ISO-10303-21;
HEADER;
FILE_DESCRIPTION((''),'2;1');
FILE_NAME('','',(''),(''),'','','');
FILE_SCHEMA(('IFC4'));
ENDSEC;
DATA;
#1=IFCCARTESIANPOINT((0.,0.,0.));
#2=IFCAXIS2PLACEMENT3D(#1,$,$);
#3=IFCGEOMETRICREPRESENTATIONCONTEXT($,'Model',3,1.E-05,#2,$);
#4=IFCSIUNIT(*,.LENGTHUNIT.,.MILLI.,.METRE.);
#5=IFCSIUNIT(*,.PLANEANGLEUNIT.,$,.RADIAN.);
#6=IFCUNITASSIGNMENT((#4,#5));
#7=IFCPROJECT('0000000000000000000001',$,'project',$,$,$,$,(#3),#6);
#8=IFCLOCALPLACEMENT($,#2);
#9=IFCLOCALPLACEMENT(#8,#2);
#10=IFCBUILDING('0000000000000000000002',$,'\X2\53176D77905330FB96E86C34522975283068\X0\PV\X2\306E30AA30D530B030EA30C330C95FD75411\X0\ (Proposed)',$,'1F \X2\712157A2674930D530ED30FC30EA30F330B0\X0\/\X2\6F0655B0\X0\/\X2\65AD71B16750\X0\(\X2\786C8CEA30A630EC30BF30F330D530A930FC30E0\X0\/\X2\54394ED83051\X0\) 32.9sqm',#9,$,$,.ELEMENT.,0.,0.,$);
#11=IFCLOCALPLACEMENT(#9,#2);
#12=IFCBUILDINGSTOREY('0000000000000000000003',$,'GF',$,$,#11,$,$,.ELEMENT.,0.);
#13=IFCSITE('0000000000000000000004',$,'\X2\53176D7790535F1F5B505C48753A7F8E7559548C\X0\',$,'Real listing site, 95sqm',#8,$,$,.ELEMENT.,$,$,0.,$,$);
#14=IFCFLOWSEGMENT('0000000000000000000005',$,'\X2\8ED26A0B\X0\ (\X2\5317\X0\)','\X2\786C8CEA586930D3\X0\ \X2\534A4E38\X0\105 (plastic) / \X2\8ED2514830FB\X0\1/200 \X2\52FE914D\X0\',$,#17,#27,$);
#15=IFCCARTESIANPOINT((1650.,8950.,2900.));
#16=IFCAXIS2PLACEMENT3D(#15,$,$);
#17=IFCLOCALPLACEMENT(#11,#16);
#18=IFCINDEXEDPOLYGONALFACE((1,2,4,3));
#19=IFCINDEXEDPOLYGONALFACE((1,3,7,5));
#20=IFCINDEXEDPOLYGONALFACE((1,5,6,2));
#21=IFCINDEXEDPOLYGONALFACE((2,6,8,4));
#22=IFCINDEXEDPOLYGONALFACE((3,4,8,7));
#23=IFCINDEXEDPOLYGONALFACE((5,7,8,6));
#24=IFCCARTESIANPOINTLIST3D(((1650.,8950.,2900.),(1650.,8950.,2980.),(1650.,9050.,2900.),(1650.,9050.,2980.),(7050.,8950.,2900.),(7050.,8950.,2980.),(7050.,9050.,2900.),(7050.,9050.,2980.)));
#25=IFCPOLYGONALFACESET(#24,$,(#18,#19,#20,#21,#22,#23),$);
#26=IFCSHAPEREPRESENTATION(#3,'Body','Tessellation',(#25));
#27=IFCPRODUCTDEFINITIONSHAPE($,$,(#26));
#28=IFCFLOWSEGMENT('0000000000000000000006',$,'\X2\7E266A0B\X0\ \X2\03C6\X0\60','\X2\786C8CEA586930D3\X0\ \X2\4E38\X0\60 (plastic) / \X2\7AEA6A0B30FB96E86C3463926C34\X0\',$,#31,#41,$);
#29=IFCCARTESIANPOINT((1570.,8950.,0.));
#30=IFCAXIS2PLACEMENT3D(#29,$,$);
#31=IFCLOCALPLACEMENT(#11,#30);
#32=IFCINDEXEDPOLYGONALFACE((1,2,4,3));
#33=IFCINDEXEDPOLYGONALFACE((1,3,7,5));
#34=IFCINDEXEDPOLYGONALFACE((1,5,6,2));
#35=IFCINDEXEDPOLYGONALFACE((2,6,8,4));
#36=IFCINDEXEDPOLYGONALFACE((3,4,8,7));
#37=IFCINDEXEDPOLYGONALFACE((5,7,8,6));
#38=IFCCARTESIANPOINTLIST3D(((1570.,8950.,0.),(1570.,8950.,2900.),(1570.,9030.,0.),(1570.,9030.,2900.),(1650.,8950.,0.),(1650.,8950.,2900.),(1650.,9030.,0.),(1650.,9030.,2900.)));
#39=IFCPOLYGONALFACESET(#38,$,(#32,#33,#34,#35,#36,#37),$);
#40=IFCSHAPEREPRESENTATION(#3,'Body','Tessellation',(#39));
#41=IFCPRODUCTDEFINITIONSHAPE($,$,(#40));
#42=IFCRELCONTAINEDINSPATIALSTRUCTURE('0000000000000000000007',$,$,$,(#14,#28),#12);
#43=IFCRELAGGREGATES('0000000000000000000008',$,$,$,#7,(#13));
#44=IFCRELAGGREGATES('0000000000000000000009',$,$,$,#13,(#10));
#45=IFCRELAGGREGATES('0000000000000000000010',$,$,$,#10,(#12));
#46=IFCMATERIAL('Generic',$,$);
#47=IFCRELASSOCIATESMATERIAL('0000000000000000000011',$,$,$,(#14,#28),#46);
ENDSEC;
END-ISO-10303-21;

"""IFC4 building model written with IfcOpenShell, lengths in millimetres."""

from ifc_helpers import new_model, si_unit, frame, frame_2d, origin, place, context, project, spatial, rectangle, extrude, material, element, save


model = new_model("IFC4")

# Units and contexts
model_context = context("Model", 3, precision=1e-05, world=origin())
ifc_project = project(units=[si_unit("LENGTHUNIT", "METRE", prefix="MILLI"), si_unit("PLANEANGLEUNIT", "RADIAN")], contexts=[model_context])

# Site, building, storey
site_placement = place(None, origin())
site = spatial("IfcSite", under=ifc_project, at=site_placement, Name="北海道弟子屈町美留和", ObjectType="Real listing site, 95sqm", CompositionType="ELEMENT", RefElevation=0.0)
building_placement = place(site_placement, origin())
building = spatial("IfcBuilding", under=site, at=building_placement, Name="北海道・雨水利用とPVのオフグリッド志向 (Proposed)", ObjectType="1F 無垢杉フローリング/漆喰/断熱材(硬質ウレタンフォーム/吹付け) 32.9sqm", CompositionType="ELEMENT", ElevationOfRefHeight=0.0, ElevationOfTerrain=0.0)
storey_placement = place(building_placement, origin())
storey = spatial("IfcBuildingStorey", under=building, at=storey_placement, Name="GF", CompositionType="ELEMENT", Elevation=0.0)

# Shared definitions
ifc_material_1 = material(Name="Generic")

# Flow segments
flow_segment_1_placement = place(storey_placement, frame((1650.0, 8950.0, 2900.0)))
element("IfcFlowSegment", 1, at=flow_segment_1_placement, inside=storey, material=ifc_material_1, Name="軒樋 (北)", Description="硬質塩ビ 半丸105 (plastic) / 軒先・1/200 勾配", context=model_context, shape_type="SweptSolid", body=[
    extrude(rectangle(XDim=5400.0, YDim=100.0, at=frame_2d((2700.0, 50.0))), frame((1650.0, 8950.0, 2900.0)), (0.0, 0.0, 1.0), 80.0),
])
flow_segment_2_placement = place(storey_placement, frame((1570.0, 8950.0, 0.0)))
element("IfcFlowSegment", 2, at=flow_segment_2_placement, inside=storey, material=ifc_material_1, Name="縦樋 φ60", Description="硬質塩ビ 丸60 (plastic) / 竪樋・雨水排水", context=model_context, shape_type="SweptSolid", body=[
    extrude(rectangle(XDim=80.0, YDim=80.0, at=frame_2d((40.0, 40.0))), frame((1570.0, 8950.0, 0.0)), (0.0, 0.0, 1.0), 2900.0),
])

save(model, "model.ifc")
